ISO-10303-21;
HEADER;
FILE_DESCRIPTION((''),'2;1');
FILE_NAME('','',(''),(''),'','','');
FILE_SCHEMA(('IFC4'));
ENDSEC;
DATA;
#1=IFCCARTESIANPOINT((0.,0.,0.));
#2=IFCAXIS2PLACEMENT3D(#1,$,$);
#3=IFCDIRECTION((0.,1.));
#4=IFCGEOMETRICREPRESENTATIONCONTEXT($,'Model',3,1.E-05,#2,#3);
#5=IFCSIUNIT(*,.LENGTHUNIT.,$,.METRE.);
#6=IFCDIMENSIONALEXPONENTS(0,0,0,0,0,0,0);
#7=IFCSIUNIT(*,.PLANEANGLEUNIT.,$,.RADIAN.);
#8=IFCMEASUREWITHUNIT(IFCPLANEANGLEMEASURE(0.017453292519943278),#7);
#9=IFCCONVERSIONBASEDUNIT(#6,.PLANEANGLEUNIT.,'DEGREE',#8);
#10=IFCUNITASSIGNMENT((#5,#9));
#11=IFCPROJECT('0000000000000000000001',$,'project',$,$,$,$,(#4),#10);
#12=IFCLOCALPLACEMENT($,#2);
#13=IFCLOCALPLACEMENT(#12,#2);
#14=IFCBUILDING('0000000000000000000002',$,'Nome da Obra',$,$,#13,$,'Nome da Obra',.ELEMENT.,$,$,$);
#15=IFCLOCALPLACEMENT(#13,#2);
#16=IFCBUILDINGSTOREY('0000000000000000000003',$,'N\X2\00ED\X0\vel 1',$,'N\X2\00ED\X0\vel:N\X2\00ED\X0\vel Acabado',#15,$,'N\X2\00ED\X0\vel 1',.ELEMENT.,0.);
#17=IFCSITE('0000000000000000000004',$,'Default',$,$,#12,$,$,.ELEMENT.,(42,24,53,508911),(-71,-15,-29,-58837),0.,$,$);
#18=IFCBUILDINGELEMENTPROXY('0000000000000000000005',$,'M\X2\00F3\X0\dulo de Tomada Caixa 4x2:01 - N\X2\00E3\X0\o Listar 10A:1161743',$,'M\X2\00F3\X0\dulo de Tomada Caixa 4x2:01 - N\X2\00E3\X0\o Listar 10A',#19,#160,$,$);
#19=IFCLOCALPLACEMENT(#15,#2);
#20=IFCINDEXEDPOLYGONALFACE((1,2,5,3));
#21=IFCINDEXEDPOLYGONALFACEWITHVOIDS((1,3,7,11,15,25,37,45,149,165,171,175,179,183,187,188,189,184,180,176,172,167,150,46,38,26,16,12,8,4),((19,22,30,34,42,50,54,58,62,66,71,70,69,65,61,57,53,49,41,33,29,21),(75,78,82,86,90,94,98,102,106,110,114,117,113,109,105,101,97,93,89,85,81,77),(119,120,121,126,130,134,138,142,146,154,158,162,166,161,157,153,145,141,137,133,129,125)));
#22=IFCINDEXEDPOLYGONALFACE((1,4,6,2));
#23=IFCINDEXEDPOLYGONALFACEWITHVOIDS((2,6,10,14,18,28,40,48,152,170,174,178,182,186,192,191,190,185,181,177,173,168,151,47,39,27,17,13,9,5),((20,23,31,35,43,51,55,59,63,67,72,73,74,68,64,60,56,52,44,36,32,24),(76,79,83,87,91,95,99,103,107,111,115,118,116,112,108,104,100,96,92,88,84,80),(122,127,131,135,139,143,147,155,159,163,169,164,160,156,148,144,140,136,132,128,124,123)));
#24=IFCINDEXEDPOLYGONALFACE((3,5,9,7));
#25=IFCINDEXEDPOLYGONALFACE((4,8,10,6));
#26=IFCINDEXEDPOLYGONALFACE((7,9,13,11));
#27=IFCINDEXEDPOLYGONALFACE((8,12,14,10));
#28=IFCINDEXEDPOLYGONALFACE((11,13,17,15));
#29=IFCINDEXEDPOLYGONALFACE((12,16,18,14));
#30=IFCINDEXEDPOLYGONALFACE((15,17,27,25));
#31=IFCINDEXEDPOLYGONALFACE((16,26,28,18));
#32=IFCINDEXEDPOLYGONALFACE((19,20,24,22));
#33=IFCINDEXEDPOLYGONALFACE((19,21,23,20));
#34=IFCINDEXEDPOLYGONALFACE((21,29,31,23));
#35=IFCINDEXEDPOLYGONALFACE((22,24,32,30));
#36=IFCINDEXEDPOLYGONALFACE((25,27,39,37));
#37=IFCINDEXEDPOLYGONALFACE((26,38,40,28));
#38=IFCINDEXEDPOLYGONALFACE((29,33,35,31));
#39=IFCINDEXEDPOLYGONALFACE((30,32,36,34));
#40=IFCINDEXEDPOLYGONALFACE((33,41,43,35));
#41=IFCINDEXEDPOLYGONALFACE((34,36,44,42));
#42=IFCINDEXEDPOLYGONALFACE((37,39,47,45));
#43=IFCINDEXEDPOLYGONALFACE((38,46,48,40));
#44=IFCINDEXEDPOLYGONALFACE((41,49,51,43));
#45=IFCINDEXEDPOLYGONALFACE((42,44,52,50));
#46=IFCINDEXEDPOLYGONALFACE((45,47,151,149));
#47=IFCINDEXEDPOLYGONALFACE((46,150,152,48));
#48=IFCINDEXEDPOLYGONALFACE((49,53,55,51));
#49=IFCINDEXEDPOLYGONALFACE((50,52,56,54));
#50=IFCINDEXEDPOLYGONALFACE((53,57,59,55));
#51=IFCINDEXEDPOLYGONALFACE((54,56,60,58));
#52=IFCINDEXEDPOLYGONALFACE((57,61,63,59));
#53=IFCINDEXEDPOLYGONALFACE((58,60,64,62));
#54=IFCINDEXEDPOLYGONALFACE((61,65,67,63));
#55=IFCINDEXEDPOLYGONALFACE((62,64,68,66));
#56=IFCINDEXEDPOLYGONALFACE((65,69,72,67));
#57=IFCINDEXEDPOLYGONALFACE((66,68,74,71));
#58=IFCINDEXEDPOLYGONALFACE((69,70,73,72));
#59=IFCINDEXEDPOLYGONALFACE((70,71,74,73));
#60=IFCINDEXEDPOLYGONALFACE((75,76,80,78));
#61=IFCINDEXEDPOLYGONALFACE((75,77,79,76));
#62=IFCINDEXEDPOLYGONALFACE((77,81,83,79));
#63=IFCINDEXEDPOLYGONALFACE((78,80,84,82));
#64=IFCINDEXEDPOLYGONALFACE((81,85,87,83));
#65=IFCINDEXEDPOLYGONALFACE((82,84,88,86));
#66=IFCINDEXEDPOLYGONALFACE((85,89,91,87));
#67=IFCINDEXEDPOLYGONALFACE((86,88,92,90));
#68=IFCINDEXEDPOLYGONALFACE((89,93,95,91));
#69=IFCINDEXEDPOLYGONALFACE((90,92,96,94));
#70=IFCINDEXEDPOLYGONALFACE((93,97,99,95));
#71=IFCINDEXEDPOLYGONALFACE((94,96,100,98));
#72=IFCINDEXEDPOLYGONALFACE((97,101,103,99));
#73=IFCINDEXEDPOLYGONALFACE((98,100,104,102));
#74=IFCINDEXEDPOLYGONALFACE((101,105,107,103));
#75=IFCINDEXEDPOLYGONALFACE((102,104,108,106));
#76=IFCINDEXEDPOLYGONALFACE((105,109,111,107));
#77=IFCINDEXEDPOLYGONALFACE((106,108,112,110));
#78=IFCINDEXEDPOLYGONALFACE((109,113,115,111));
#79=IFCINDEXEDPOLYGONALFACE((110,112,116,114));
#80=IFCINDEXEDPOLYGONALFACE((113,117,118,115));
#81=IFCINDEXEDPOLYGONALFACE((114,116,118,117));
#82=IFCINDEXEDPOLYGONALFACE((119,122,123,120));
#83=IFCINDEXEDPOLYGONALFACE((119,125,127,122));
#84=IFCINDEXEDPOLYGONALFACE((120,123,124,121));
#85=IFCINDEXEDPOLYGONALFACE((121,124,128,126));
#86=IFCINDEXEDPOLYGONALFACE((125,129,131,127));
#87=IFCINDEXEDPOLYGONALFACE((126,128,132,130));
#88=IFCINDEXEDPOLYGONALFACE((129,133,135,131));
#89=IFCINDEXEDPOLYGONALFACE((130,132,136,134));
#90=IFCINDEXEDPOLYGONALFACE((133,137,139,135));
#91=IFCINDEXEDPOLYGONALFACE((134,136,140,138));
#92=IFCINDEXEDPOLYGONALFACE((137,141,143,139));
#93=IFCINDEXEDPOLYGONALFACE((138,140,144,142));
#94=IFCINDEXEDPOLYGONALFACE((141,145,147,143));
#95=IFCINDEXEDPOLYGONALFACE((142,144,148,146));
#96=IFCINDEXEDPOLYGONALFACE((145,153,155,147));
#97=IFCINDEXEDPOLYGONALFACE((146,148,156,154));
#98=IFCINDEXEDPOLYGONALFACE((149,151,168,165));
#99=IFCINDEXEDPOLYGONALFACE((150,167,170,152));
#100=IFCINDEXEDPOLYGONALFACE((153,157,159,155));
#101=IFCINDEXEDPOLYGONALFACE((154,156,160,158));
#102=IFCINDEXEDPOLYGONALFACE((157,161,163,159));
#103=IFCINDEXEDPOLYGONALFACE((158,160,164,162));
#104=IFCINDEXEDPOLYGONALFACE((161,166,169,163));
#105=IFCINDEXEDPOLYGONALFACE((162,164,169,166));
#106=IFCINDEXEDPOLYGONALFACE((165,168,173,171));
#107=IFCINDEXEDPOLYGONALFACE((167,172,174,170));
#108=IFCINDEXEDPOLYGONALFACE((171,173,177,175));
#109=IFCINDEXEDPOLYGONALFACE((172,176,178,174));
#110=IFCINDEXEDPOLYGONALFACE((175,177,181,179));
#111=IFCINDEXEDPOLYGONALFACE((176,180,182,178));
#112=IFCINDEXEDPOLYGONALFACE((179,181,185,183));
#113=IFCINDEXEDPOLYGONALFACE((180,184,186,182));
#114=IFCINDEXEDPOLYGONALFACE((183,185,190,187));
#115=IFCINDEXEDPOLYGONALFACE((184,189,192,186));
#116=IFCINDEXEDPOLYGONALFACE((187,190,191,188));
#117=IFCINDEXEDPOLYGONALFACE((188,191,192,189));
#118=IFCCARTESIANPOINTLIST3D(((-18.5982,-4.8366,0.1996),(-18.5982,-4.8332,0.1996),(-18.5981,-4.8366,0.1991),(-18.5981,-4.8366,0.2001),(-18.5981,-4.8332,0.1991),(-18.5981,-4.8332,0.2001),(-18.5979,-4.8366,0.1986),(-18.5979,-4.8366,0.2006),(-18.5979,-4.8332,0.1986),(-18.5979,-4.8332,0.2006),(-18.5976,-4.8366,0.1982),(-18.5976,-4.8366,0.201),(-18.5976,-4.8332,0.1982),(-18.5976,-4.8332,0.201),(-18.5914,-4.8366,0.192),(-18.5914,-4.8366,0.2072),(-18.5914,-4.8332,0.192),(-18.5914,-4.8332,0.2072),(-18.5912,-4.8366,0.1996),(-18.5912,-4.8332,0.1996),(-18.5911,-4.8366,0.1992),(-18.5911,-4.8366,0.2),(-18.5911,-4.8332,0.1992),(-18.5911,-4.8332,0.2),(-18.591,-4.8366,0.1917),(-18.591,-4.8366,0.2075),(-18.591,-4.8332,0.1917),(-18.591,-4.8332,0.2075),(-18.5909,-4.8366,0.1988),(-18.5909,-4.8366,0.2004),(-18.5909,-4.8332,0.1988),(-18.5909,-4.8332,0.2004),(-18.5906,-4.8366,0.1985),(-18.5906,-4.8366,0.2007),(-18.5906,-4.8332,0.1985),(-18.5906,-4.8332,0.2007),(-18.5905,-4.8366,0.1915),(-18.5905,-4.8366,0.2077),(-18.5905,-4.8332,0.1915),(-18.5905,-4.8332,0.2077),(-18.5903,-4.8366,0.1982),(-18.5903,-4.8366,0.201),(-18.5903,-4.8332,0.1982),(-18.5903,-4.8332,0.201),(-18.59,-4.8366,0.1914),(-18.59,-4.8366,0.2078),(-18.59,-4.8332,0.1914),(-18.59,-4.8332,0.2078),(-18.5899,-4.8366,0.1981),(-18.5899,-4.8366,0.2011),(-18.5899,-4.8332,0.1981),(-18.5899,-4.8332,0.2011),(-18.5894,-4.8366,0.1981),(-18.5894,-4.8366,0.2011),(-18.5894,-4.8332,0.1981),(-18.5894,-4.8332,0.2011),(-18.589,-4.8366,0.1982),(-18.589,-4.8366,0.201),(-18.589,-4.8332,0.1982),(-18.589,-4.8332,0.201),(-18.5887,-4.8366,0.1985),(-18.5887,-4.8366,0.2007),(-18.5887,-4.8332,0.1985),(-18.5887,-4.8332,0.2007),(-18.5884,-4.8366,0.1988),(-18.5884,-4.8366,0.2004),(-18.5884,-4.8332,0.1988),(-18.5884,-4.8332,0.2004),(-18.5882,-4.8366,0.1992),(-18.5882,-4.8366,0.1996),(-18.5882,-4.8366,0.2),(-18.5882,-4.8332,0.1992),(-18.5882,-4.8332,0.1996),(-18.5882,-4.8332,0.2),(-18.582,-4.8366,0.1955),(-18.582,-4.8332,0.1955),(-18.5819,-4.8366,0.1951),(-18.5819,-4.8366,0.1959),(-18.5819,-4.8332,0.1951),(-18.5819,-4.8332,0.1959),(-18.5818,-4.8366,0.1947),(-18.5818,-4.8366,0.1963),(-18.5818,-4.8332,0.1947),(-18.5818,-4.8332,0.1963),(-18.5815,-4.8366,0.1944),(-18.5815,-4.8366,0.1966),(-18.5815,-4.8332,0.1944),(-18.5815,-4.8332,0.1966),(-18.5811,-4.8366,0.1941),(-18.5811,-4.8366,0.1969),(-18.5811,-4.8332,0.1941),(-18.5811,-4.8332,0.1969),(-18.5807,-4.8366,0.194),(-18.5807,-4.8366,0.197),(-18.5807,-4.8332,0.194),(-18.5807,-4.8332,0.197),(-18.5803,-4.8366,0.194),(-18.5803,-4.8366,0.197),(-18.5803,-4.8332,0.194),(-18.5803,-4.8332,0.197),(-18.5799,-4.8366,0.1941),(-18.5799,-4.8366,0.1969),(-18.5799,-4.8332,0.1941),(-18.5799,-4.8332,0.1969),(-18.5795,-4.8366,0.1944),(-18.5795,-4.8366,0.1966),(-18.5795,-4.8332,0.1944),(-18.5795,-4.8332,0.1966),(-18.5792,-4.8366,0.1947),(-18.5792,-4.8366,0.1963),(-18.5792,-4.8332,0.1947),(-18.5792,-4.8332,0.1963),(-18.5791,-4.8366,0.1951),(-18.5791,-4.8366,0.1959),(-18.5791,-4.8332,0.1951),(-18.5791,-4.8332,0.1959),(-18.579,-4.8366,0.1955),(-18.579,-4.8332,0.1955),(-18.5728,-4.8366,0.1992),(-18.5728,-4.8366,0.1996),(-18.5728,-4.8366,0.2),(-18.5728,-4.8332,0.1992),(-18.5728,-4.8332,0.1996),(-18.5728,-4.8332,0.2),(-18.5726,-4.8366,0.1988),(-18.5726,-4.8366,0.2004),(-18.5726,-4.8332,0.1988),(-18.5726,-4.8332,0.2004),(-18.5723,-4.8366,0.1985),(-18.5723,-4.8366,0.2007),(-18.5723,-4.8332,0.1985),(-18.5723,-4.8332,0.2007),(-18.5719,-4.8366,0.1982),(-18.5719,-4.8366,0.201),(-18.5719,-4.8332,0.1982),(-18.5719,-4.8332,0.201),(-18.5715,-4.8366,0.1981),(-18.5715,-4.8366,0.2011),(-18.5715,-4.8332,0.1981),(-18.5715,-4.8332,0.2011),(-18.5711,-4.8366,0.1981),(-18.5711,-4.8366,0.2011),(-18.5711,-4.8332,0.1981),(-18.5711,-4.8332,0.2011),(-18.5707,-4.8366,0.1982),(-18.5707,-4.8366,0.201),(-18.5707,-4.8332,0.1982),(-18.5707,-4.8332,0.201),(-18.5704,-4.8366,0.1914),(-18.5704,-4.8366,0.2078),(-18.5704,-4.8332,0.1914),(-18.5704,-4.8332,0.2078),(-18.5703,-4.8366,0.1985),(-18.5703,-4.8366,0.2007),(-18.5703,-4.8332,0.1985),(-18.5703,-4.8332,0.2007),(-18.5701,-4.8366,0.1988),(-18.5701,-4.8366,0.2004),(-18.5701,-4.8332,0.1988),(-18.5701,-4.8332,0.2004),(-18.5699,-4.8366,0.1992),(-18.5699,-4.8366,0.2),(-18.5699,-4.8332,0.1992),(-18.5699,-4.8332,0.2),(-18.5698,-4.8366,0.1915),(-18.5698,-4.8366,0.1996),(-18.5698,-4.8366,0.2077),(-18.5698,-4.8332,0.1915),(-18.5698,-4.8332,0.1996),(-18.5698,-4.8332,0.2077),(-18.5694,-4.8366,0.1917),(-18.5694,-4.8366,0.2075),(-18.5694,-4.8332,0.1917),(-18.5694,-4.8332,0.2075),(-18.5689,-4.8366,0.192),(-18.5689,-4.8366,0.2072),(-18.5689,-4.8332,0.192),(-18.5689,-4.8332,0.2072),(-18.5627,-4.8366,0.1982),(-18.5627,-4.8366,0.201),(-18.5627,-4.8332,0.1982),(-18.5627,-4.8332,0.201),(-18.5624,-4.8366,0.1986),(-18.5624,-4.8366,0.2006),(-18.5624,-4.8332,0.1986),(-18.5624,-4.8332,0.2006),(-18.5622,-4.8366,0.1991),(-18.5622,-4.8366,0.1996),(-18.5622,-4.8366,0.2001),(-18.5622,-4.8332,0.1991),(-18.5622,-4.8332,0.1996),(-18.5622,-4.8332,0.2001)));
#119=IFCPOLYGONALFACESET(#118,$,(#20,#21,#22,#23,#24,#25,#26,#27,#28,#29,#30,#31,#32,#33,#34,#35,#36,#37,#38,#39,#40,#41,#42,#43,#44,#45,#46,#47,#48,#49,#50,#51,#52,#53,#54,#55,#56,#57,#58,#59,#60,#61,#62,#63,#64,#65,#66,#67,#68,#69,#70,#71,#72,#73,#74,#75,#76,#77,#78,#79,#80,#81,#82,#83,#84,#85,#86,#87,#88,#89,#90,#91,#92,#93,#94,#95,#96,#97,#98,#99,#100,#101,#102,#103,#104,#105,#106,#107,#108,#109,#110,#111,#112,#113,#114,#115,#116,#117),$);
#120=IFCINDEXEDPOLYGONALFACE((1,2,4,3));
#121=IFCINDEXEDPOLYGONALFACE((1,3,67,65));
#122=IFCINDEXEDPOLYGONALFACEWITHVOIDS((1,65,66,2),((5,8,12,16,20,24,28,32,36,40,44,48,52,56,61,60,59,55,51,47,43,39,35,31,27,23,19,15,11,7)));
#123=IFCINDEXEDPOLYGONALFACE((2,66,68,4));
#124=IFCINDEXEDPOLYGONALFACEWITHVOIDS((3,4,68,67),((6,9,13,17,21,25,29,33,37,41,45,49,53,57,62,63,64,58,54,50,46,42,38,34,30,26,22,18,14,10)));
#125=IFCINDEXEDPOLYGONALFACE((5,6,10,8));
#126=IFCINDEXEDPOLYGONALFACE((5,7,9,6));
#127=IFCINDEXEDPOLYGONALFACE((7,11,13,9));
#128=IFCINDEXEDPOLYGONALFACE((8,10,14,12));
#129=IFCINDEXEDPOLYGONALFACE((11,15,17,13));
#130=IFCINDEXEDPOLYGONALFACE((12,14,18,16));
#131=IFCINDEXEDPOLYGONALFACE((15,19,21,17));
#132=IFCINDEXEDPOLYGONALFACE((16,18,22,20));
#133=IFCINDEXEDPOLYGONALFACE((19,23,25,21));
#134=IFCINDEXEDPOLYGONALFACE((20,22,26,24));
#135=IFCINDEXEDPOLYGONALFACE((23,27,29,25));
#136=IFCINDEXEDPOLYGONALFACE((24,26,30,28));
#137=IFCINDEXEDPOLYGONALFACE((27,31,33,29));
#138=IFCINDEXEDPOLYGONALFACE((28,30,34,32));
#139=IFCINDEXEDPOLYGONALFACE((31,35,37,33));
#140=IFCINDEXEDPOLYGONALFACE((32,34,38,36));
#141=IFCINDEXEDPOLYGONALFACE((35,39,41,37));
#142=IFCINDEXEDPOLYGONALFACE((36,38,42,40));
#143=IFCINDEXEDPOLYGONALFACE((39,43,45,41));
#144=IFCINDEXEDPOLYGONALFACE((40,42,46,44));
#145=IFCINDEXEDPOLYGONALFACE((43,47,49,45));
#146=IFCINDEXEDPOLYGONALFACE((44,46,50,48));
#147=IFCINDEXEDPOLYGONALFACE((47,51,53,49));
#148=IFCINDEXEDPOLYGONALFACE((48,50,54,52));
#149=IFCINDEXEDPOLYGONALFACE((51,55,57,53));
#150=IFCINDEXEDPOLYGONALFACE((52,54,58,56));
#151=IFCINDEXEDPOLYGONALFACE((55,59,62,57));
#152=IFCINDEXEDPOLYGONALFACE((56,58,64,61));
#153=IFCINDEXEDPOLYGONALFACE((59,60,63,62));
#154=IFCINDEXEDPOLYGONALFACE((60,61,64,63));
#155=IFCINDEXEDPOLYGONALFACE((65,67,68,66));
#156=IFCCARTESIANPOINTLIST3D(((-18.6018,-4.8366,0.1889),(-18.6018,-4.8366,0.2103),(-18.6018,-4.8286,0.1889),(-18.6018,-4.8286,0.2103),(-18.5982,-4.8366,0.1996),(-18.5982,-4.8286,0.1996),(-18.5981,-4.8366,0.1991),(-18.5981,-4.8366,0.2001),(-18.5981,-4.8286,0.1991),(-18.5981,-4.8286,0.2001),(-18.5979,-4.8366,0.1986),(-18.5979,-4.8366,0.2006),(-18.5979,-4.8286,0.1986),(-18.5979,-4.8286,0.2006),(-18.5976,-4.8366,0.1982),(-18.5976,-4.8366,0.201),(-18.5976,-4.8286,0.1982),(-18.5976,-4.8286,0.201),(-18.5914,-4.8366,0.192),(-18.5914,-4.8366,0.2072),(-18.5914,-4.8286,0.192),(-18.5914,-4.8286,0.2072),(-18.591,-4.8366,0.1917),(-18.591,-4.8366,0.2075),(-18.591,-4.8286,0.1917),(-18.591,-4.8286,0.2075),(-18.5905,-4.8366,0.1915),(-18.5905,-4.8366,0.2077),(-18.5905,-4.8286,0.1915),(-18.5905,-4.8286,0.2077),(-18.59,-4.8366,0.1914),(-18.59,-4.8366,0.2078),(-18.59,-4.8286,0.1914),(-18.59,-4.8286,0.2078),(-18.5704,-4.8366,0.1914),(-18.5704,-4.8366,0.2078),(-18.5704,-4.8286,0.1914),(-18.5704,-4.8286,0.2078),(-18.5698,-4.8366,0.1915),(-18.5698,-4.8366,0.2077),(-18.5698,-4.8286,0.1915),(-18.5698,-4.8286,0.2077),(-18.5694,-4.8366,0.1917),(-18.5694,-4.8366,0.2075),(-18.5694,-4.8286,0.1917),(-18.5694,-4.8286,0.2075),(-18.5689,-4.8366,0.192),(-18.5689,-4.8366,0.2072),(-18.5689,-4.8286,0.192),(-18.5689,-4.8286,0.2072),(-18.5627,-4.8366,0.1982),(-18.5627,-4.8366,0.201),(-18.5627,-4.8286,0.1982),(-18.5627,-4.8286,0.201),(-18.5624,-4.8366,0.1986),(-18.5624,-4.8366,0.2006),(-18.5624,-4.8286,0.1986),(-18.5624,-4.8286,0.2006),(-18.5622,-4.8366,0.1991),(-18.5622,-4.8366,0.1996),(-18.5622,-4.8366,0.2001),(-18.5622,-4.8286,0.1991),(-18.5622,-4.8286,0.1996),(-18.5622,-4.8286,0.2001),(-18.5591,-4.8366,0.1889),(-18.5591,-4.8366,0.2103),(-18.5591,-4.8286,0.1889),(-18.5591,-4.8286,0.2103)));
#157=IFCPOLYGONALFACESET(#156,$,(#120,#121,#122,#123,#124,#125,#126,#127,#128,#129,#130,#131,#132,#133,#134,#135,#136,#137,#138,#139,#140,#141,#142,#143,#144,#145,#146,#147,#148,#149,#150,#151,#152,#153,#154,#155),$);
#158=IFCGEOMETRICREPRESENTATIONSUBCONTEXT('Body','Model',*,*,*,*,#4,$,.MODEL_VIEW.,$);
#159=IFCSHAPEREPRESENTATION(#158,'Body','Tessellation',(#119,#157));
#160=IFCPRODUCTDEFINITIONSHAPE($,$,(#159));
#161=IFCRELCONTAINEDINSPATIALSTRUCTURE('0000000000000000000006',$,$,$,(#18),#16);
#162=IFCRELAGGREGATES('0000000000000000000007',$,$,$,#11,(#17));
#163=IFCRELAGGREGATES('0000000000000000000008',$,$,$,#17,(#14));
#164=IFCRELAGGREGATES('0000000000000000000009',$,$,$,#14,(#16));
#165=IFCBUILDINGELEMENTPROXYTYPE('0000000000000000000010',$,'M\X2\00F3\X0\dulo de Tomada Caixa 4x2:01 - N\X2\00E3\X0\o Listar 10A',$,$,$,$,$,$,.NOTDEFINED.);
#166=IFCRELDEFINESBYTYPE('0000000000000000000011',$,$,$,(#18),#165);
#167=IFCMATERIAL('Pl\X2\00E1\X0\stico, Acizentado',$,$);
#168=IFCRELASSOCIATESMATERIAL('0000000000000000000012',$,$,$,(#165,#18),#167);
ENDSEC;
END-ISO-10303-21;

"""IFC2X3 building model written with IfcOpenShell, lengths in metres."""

from ifc_helpers import new_model, entity, si_unit, converted_unit, direction, frame, frame_2d, origin, place, context, subcontext, project, spatial, polyline, circle_curve, parameter, trimmed, segment, composite_curve, outline, extrude, source, transform, mapped, material, type_object, type_shapes, element, save


model = new_model("IFC2X3")

# Units and contexts
model_context = context("Model", 3, precision=1e-05, world=origin(), true_north=direction((0.0, 1.0)))
body_context = subcontext(model_context, "Body", "Model", "MODEL_VIEW")
ifc_project = project(units=[si_unit("LENGTHUNIT", "METRE"), converted_unit("PLANEANGLEUNIT", "DEGREE", entity("IfcPlaneAngleMeasure", 0.017453292519943278), si_unit("PLANEANGLEUNIT", "RADIAN"), dimensions=[0, 0, 0, 0, 0, 0, 0])], contexts=[model_context])

# Site, building, storey
site_placement = place(None, origin())
site = spatial("IfcSite", under=ifc_project, at=site_placement, Name="Default", CompositionType="ELEMENT", RefLatitude=(42, 24, 53, 508911), RefLongitude=(-71, -15, -29, -58837), RefElevation=0.0)
building_placement = place(site_placement, origin())
building = spatial("IfcBuilding", under=site, at=building_placement, Name="Nome da Obra", LongName="Nome da Obra", CompositionType="ELEMENT")
storey_placement = place(building_placement, origin())
storey = spatial("IfcBuildingStorey", under=building, at=storey_placement, Name="Nível 1", ObjectType="Nível:Nível Acabado", LongName="Nível 1", CompositionType="ELEMENT", Elevation=0.0)

# Building element proxy
ifc_material_1 = material(Name="Plástico, Acizentado")
building_element_proxy_type_1 = type_object("IfcBuildingElementProxyType", Name="Módulo de Tomada Caixa 4x2:01 - Não Listar 10A", PredefinedType="NOTDEFINED", material=ifc_material_1)
shared_shape_1 = source(origin(), body_context, "Body", "SweptSolid", [
    extrude(outline(composite_curve([segment(polyline([(-0.0098, -0.0082), (0.0098, -0.0082)]), True, "CONTINUOUS"), segment(trimmed(circle_curve(frame_2d((0.0098, -0.0062), x_axis=(1.0, 0.0)), 0.002), [parameter(270.0)], [parameter(315.0)], True, "PARAMETER"), True, "CONTINUOUS"), segment(polyline([(0.0112, -0.0076), (0.0174, -0.0014)]), True, "CONTINUOUS"), segment(trimmed(circle_curve(frame_2d((0.016, 0.0), x_axis=(1.0, 0.0)), 0.002), [parameter(315.0)], [parameter(45.0)], True, "PARAMETER"), True, "CONTINUOUS"), segment(polyline([(0.0174, 0.0014), (0.0112, 0.0076)]), True, "CONTINUOUS"), segment(trimmed(circle_curve(frame_2d((0.0098, 0.0062), x_axis=(1.0, 0.0)), 0.002), [parameter(45.0)], [parameter(90.0)], True, "PARAMETER"), True, "CONTINUOUS"), segment(polyline([(0.0098, 0.0082), (-0.0098, 0.0082)]), True, "CONTINUOUS"), segment(trimmed(circle_curve(frame_2d((-0.0098, 0.0062), x_axis=(1.0, 0.0)), 0.002), [parameter(90.0)], [parameter(135.0)], True, "PARAMETER"), True, "CONTINUOUS"), segment(polyline([(-0.0112, 0.0076), (-0.0174, 0.0014)]), True, "CONTINUOUS"), segment(trimmed(circle_curve(frame_2d((-0.016, 0.0), x_axis=(1.0, 0.0)), 0.002), [parameter(135.0)], [parameter(225.0)], True, "PARAMETER"), True, "CONTINUOUS"), segment(polyline([(-0.0174, -0.0014), (-0.0112, -0.0076)]), True, "CONTINUOUS"), segment(trimmed(circle_curve(frame_2d((-0.0098, -0.0062), x_axis=(1.0, 0.0)), 0.002), [parameter(225.0)], [parameter(270.0)], True, "PARAMETER"), True, "CONTINUOUS")], self_intersect=False), holes=[composite_curve([segment(trimmed(circle_curve(frame_2d((0.0089, 0.0), x_axis=(1.0, 0.0)), 0.0015), [parameter(0.0)], [parameter(180.0)], True, "PARAMETER"), False, "CONTINUOUS"), segment(trimmed(circle_curve(frame_2d((0.0089, 0.0), x_axis=(1.0, 0.0)), 0.0015), [parameter(180.0)], [parameter(0.0)], True, "PARAMETER"), False, "CONTINUOUS")], self_intersect=False), composite_curve([segment(trimmed(circle_curve(frame_2d((-0.0003, 0.0041), x_axis=(1.0, 0.0)), 0.0015), [parameter(0.0)], [parameter(180.0)], True, "PARAMETER"), False, "CONTINUOUS"), segment(trimmed(circle_curve(frame_2d((-0.0003, 0.0041), x_axis=(1.0, 0.0)), 0.0015), [parameter(180.0)], [parameter(0.0)], True, "PARAMETER"), False, "CONTINUOUS")], self_intersect=False), composite_curve([segment(trimmed(circle_curve(frame_2d((-0.0095, 0.0), x_axis=(1.0, 0.0)), 0.0015), [parameter(0.0)], [parameter(180.0)], True, "PARAMETER"), False, "CONTINUOUS"), segment(trimmed(circle_curve(frame_2d((-0.0095, 0.0), x_axis=(1.0, 0.0)), 0.0015), [parameter(180.0)], [parameter(0.0)], True, "PARAMETER"), False, "CONTINUOUS")], self_intersect=False)]), frame((0.0003, 0.0, 0.125), z_axis=(0.0, 1.0, 0.0), x_axis=(1.0, 0.0, 0.0)), (0.0, 0.0, 1.0), 0.0034),
    extrude(outline(polyline([(-0.0214, -0.0107), (0.0214, -0.0107), (0.0214, 0.0107), (-0.0214, 0.0107), (-0.0214, -0.0107)]), holes=[composite_curve([segment(polyline([(0.0101, -0.0082), (-0.0095, -0.0082)]), True, "CONTINUOUS"), segment(trimmed(circle_curve(frame_2d((-0.0095, -0.0062), x_axis=(1.0, 0.0)), 0.002), [parameter(225.0)], [parameter(270.0)], True, "PARAMETER"), False, "CONTINUOUS"), segment(polyline([(-0.0109, -0.0076), (-0.0171, -0.0014)]), True, "CONTINUOUS"), segment(trimmed(circle_curve(frame_2d((-0.0157, 0.0), x_axis=(1.0, 0.0)), 0.002), [parameter(135.0)], [parameter(225.0)], True, "PARAMETER"), False, "CONTINUOUS"), segment(polyline([(-0.0171, 0.0014), (-0.0109, 0.0076)]), True, "CONTINUOUS"), segment(trimmed(circle_curve(frame_2d((-0.0095, 0.0062), x_axis=(1.0, 0.0)), 0.002), [parameter(90.0)], [parameter(135.0)], True, "PARAMETER"), False, "CONTINUOUS"), segment(polyline([(-0.0095, 0.0082), (0.0101, 0.0082)]), True, "CONTINUOUS"), segment(trimmed(circle_curve(frame_2d((0.0101, 0.0062), x_axis=(1.0, 0.0)), 0.002), [parameter(45.0)], [parameter(90.0)], True, "PARAMETER"), False, "CONTINUOUS"), segment(polyline([(0.0115, 0.0076), (0.0177, 0.0014)]), True, "CONTINUOUS"), segment(trimmed(circle_curve(frame_2d((0.0163, 0.0), x_axis=(1.0, 0.0)), 0.002), [parameter(315.0)], [parameter(45.0)], True, "PARAMETER"), False, "CONTINUOUS"), segment(polyline([(0.0177, -0.0014), (0.0115, -0.0076)]), True, "CONTINUOUS"), segment(trimmed(circle_curve(frame_2d((0.0101, -0.0062), x_axis=(1.0, 0.0)), 0.002), [parameter(270.0)], [parameter(315.0)], True, "PARAMETER"), False, "CONTINUOUS")], self_intersect=False)]), frame((0.0, 0.0, 0.125), z_axis=(0.0, 1.0, 0.0), x_axis=(1.0, 0.0, 0.0)), (0.0, 0.0, 1.0), 0.008),
])
type_shapes(building_element_proxy_type_1, [shared_shape_1])
for number, where, name in (
    (1, (-18.5805, -4.8366, 0.0746), "Módulo de Tomada Caixa 4x2:01 - Não Listar 10A:1161743"),
):
    element("IfcBuildingElementProxy", number, at=place(storey_placement, frame(where)), inside=storey, type_object=building_element_proxy_type_1, material=ifc_material_1, Name=name, ObjectType="Módulo de Tomada Caixa 4x2:01 - Não Listar 10A", context=body_context, shape_type="MappedRepresentation", body=[
        mapped(shared_shape_1, transform((0.0, 0.0, 0.0), scale=1.0)),
    ])

save(model, "model.ifc")
